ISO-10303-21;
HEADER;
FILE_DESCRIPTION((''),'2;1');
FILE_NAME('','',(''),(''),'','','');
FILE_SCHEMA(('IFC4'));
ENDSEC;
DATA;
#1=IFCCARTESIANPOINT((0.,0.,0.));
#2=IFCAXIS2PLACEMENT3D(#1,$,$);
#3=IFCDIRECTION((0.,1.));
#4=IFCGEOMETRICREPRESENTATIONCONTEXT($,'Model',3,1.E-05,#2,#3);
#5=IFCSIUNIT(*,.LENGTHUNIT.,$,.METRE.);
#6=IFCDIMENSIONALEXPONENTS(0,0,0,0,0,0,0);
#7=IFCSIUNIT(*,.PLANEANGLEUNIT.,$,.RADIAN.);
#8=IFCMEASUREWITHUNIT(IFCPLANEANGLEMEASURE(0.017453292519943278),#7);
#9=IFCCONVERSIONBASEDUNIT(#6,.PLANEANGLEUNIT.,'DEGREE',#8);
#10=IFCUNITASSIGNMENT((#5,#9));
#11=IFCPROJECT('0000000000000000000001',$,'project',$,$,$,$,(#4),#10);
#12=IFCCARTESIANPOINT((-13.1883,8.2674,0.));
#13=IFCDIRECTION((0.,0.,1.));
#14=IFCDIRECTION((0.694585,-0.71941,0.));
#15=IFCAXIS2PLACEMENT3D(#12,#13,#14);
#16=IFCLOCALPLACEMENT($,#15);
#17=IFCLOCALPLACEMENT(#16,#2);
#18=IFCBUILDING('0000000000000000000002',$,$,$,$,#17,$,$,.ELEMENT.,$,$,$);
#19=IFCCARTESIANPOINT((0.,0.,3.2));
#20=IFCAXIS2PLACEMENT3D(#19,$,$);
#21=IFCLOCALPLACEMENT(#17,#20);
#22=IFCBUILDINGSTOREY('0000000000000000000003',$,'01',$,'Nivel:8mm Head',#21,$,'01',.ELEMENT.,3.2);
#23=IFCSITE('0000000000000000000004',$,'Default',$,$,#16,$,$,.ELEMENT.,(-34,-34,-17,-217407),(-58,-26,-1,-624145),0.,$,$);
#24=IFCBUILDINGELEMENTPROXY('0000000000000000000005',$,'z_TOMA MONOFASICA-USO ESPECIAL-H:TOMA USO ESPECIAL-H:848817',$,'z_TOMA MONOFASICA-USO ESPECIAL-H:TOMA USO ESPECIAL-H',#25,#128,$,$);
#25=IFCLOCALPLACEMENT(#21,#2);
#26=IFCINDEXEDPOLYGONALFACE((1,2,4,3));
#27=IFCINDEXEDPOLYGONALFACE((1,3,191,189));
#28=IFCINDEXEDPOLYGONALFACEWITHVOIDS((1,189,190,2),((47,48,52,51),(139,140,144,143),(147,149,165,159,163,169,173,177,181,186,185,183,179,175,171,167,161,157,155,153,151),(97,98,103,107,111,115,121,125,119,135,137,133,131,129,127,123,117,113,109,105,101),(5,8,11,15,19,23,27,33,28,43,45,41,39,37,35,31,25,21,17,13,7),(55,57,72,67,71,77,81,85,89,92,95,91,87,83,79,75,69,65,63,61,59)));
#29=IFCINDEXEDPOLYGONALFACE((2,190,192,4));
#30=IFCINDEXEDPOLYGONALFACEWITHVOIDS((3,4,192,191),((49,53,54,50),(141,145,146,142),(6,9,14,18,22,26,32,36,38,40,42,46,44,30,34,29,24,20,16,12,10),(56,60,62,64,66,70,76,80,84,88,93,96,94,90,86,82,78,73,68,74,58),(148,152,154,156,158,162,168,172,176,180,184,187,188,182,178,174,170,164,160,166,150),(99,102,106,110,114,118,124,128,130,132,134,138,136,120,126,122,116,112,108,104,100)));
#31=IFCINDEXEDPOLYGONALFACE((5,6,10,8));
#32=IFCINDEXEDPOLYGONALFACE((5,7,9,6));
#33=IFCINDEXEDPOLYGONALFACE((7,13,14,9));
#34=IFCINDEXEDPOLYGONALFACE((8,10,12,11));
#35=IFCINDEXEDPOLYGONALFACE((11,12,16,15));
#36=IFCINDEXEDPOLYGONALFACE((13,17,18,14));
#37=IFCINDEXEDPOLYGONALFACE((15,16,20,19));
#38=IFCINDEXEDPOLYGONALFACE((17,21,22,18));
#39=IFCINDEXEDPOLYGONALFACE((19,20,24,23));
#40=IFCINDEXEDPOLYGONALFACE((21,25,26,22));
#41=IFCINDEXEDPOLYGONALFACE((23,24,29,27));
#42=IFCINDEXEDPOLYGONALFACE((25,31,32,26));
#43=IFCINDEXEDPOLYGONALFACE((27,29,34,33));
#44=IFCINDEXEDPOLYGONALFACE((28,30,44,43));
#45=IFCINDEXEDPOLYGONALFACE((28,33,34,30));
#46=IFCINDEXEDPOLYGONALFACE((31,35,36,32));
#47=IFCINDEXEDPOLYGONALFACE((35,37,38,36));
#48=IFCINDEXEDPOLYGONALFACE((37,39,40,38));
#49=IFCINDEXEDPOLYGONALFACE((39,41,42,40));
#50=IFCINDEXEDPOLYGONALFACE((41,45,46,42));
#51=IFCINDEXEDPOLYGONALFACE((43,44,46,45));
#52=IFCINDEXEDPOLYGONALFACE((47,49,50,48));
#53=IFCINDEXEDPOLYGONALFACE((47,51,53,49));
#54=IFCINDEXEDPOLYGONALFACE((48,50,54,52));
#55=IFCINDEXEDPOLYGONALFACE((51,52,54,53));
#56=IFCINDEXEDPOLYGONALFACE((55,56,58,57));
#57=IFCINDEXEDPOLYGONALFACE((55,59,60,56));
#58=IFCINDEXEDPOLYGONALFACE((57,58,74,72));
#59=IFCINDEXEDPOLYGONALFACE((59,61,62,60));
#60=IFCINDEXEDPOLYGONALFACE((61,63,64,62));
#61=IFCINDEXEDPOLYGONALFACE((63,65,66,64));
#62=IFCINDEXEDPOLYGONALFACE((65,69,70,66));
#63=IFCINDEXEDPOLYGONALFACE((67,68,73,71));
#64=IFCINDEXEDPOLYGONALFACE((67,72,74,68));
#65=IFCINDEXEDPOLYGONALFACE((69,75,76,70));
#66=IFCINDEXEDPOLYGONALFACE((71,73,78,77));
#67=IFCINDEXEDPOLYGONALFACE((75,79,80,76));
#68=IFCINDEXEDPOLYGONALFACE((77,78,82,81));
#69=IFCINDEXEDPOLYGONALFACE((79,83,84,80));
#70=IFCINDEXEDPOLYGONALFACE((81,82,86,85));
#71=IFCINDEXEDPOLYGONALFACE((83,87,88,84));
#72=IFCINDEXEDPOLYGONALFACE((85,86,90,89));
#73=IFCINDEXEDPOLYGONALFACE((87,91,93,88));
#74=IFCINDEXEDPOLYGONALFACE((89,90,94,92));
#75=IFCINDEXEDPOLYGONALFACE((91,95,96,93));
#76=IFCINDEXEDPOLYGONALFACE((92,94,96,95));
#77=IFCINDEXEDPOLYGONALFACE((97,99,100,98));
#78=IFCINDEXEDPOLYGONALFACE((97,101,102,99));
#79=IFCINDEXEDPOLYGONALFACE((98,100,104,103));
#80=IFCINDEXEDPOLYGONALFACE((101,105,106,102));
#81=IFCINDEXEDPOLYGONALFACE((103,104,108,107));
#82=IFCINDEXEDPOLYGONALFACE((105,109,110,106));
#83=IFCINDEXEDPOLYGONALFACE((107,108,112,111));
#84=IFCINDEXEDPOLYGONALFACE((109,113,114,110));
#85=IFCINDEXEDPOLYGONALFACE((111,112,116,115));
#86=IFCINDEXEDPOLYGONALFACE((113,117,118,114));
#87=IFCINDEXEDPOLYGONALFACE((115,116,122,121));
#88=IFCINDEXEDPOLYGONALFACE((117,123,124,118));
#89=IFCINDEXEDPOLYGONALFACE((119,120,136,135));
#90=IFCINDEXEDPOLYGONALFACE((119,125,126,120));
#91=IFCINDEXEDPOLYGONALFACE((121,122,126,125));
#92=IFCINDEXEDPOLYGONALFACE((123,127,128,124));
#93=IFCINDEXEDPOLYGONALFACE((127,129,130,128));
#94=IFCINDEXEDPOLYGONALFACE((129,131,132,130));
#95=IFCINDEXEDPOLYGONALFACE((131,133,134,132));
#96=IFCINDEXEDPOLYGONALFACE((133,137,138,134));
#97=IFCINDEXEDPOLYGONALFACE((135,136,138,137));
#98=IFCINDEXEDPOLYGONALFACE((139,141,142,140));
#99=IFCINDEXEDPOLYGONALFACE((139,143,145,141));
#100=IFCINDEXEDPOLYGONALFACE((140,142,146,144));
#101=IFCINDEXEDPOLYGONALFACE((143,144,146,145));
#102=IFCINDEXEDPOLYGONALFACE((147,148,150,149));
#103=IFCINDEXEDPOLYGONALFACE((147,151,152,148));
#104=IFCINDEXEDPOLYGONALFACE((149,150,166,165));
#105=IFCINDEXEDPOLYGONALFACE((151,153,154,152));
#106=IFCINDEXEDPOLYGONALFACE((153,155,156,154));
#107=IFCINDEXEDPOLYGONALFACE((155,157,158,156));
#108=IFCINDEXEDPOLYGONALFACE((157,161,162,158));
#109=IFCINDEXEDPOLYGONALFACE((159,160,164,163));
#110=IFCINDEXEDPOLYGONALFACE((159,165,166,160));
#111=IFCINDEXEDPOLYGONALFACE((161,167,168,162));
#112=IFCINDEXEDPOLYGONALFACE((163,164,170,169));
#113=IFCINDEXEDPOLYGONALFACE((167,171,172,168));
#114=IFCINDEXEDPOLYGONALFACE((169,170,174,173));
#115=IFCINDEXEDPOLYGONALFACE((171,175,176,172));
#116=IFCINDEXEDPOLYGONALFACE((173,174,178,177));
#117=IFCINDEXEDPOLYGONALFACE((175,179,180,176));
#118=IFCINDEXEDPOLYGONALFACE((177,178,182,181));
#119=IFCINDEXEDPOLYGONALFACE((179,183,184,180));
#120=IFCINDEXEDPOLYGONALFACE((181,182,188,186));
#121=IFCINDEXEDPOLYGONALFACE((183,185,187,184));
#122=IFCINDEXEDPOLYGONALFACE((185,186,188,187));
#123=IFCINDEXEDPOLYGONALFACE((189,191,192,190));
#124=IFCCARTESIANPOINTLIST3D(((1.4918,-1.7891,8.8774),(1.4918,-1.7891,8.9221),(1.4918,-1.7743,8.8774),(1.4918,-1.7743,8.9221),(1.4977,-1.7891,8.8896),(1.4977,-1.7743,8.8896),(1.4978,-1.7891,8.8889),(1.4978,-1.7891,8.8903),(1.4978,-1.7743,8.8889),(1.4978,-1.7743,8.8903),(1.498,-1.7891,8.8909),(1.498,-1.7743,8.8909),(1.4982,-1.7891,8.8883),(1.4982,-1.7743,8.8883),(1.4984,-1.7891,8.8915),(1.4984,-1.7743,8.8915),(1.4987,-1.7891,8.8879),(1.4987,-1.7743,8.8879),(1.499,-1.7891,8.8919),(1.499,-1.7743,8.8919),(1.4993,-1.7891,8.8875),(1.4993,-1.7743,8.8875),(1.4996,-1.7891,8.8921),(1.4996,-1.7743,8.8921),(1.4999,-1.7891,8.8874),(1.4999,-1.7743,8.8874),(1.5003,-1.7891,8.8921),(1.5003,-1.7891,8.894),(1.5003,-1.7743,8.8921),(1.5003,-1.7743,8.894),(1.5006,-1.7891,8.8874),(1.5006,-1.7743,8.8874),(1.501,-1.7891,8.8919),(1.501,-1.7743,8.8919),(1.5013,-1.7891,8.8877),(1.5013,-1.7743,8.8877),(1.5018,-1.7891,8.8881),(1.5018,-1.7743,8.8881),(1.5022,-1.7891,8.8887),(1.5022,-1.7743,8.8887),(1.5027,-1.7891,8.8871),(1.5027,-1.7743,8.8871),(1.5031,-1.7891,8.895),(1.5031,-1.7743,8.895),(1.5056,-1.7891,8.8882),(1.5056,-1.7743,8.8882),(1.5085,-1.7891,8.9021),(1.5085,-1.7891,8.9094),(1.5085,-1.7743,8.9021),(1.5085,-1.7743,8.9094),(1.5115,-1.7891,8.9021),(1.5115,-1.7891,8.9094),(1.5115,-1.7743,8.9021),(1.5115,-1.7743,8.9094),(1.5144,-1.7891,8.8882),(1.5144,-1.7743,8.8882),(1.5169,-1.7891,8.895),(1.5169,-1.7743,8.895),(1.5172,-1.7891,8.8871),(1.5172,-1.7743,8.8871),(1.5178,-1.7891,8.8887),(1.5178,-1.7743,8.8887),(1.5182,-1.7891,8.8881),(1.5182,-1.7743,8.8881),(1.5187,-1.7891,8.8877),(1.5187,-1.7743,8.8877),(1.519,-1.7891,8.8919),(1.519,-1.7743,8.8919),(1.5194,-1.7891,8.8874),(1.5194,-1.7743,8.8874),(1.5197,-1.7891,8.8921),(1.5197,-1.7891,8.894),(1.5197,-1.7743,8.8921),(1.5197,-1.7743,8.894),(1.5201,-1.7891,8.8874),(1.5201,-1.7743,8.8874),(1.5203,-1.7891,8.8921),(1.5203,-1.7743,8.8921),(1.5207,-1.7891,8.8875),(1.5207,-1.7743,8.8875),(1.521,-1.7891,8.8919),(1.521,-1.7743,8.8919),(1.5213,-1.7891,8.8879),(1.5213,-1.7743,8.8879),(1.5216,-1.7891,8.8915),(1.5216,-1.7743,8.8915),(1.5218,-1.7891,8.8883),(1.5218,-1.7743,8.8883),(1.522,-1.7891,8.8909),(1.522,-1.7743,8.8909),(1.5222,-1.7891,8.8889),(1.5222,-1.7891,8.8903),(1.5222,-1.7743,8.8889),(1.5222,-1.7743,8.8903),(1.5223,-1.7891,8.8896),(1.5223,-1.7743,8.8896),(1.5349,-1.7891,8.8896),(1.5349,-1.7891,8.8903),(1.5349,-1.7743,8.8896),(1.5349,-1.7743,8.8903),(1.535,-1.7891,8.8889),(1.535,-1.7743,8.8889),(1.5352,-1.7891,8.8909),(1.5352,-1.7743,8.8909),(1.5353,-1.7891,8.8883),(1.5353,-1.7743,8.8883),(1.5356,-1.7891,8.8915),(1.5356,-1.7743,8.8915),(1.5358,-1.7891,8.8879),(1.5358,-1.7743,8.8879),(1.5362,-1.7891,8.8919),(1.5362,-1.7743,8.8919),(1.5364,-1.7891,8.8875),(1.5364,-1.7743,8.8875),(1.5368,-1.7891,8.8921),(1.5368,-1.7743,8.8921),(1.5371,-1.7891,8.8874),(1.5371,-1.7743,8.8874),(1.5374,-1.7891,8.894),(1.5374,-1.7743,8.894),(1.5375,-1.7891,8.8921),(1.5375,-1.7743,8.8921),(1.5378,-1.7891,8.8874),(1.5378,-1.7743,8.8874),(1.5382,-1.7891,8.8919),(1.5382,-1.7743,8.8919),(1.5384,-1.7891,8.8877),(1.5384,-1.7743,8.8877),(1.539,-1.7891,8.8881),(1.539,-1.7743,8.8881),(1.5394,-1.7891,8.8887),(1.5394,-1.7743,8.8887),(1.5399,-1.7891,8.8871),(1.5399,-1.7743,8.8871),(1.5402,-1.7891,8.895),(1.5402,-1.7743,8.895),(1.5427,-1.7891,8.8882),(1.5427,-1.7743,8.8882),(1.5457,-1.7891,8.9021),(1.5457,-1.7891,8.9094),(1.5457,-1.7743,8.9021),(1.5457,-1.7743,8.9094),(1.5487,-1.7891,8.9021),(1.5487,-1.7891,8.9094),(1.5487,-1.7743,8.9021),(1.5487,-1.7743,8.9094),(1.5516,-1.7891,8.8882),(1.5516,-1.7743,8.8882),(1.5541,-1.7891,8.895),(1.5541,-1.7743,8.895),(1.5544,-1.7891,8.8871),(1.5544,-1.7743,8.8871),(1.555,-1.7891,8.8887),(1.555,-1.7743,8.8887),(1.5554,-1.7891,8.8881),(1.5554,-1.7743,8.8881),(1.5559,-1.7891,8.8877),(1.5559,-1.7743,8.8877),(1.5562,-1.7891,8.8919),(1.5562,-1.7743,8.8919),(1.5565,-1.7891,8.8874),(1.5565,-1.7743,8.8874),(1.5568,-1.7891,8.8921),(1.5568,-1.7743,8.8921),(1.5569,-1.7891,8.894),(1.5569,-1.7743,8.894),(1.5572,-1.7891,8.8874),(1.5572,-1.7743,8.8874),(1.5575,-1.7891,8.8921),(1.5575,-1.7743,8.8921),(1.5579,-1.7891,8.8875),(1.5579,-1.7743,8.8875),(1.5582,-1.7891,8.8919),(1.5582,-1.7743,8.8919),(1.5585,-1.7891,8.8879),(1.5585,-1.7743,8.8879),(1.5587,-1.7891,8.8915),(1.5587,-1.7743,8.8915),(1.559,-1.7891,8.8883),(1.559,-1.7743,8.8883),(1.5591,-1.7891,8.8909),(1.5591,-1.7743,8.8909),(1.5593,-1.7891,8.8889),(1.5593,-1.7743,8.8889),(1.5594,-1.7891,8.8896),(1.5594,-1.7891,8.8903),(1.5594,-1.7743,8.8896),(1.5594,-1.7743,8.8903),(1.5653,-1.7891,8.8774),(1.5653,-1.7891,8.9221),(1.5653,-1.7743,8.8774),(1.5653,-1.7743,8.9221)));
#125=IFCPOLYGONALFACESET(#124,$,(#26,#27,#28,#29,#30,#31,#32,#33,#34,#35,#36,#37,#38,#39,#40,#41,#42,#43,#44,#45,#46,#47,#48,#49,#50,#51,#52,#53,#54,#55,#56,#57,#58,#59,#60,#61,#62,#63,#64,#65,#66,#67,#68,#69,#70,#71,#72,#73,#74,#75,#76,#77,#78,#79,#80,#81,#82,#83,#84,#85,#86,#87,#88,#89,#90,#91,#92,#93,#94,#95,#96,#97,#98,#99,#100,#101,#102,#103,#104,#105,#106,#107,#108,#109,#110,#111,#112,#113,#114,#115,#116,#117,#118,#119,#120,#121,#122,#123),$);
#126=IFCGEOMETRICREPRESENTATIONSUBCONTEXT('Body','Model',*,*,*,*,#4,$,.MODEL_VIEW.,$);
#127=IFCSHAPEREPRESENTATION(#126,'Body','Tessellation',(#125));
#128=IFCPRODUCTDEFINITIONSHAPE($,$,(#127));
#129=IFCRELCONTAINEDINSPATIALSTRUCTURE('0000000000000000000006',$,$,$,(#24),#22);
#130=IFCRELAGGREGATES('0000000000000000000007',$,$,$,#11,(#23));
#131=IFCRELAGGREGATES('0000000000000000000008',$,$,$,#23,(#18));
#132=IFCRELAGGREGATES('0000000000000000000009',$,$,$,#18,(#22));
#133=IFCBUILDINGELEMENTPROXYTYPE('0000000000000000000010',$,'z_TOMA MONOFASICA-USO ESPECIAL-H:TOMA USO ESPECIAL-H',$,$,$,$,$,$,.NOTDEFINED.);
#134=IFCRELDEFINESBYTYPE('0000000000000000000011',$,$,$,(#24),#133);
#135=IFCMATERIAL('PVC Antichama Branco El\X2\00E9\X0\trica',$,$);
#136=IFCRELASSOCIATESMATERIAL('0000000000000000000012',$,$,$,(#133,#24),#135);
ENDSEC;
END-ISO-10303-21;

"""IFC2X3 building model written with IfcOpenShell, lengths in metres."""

from ifc_helpers import new_model, entity, si_unit, converted_unit, direction, frame, frame_2d, origin, place, context, subcontext, project, spatial, polyline, circle_curve, parameter, trimmed, segment, composite_curve, outline, extrude, source, transform, mapped, material, type_object, type_shapes, element, save


model = new_model("IFC2X3")

# Units and contexts
model_context = context("Model", 3, precision=1e-05, world=origin(), true_north=direction((0.0, 1.0)))
body_context = subcontext(model_context, "Body", "Model", "MODEL_VIEW")
ifc_project = project(units=[si_unit("LENGTHUNIT", "METRE"), converted_unit("PLANEANGLEUNIT", "DEGREE", entity("IfcPlaneAngleMeasure", 0.017453292519943278), si_unit("PLANEANGLEUNIT", "RADIAN"), dimensions=[0, 0, 0, 0, 0, 0, 0])], contexts=[model_context])

# Site, building, storey
site_placement = place(None, frame((-13.1883, 8.2674, 0.0), z_axis=(0.0, 0.0, 1.0), x_axis=(0.694585, -0.71941, 0.0)))
site = spatial("IfcSite", under=ifc_project, at=site_placement, Name="Default", CompositionType="ELEMENT", RefLatitude=(-34, -34, -17, -217407), RefLongitude=(-58, -26, -1, -624145), RefElevation=0.0)
building_placement = place(site_placement, origin())
building = spatial("IfcBuilding", under=site, at=building_placement, CompositionType="ELEMENT")
storey_placement = place(building_placement, frame((0.0, 0.0, 3.2)))
storey = spatial("IfcBuildingStorey", under=building, at=storey_placement, Name="01", ObjectType="Nivel:8mm Head", LongName="01", CompositionType="ELEMENT", Elevation=3.2)

# Building element proxy
ifc_material_1 = material(Name="PVC Antichama Branco Elétrica")
building_element_proxy_type_1 = type_object("IfcBuildingElementProxyType", Name="z_TOMA MONOFASICA-USO ESPECIAL-H:TOMA USO ESPECIAL-H", PredefinedType="NOTDEFINED", material=ifc_material_1)
shared_shape_1 = source(origin(), body_context, "Body", "SweptSolid", [
    extrude(outline(polyline([(-0.0368, -0.0223), (0.0368, -0.0223), (0.0368, 0.0223), (-0.0368, 0.0223), (-0.0368, -0.0223)]), holes=[composite_curve([segment(polyline([(0.0141, 0.0115), (0.0116, 0.0047)]), True, "CONTINUOUS"), segment(polyline([(0.0116, 0.0047), (0.0088, 0.0057)]), True, "CONTINUOUS"), segment(polyline([(0.0088, 0.0057), (0.0096, 0.0078)]), True, "CONTINUOUS"), segment(trimmed(circle_curve(frame_2d((0.0087, 0.0099), x_axis=(1.0, 0.0)), 0.0024), [parameter(27.118901)], [parameter(292.881099)], True, "PARAMETER"), False, "CONTINUOUS"), segment(polyline([(0.0108, 0.011), (0.0113, 0.0126)]), True, "CONTINUOUS"), segment(polyline([(0.0113, 0.0126), (0.0141, 0.0115)]), True, "CONTINUOUS")], self_intersect=False), composite_curve([segment(polyline([(0.0255, 0.0047), (0.023, 0.0115)]), True, "CONTINUOUS"), segment(polyline([(0.023, 0.0115), (0.0258, 0.0126)]), True, "CONTINUOUS"), segment(polyline([(0.0258, 0.0126), (0.0264, 0.011)]), True, "CONTINUOUS"), segment(trimmed(circle_curve(frame_2d((0.0285, 0.0099), x_axis=(1.0, 0.0)), 0.0024), [parameter(247.118901)], [parameter(152.881099)], True, "PARAMETER"), False, "CONTINUOUS"), segment(polyline([(0.0276, 0.0078), (0.0283, 0.0057)]), True, "CONTINUOUS"), segment(polyline([(0.0283, 0.0057), (0.0255, 0.0047)]), True, "CONTINUOUS")], self_intersect=False), polyline([(0.0201, -0.0024), (0.0201, -0.0097), (0.0171, -0.0097), (0.0171, -0.0024), (0.0201, -0.0024)]), composite_curve([segment(polyline([(-0.0141, 0.0115), (-0.0113, 0.0126)]), True, "CONTINUOUS"), segment(polyline([(-0.0113, 0.0126), (-0.0108, 0.011)]), True, "CONTINUOUS"), segment(trimmed(circle_curve(frame_2d((-0.0087, 0.0099), x_axis=(1.0, 0.0)), 0.0024), [parameter(247.118901)], [parameter(152.881099)], True, "PARAMETER"), False, "CONTINUOUS"), segment(polyline([(-0.0096, 0.0078), (-0.0088, 0.0057)]), True, "CONTINUOUS"), segment(polyline([(-0.0088, 0.0057), (-0.0116, 0.0047)]), True, "CONTINUOUS"), segment(polyline([(-0.0116, 0.0047), (-0.0141, 0.0115)]), True, "CONTINUOUS")], self_intersect=False), composite_curve([segment(polyline([(-0.0255, 0.0047), (-0.0283, 0.0057)]), True, "CONTINUOUS"), segment(polyline([(-0.0283, 0.0057), (-0.0276, 0.0078)]), True, "CONTINUOUS"), segment(trimmed(circle_curve(frame_2d((-0.0285, 0.0099), x_axis=(1.0, 0.0)), 0.0024), [parameter(27.118901)], [parameter(292.881099)], True, "PARAMETER"), False, "CONTINUOUS"), segment(polyline([(-0.0264, 0.011), (-0.0258, 0.0126)]), True, "CONTINUOUS"), segment(polyline([(-0.0258, 0.0126), (-0.023, 0.0115)]), True, "CONTINUOUS"), segment(polyline([(-0.023, 0.0115), (-0.0255, 0.0047)]), True, "CONTINUOUS")], self_intersect=False), polyline([(-0.0201, -0.0024), (-0.0171, -0.0024), (-0.0171, -0.0097), (-0.0201, -0.0097), (-0.0201, -0.0024)])]), frame((0.0, -0.005, 0.0223), z_axis=(0.0, 1.0, 0.0), x_axis=(1.0, 0.0, 0.0)), (0.0, 0.0, 1.0), 0.0148),
])
type_shapes(building_element_proxy_type_1, [shared_shape_1])
for number, where, z_axis, x_axis, name in (
    (1, (1.5286, -1.7793, 8.8774), (0.0, 0.0, 1.0), (-1.0, 0.0, 0.0), "z_TOMA MONOFASICA-USO ESPECIAL-H:TOMA USO ESPECIAL-H:848817"),
):
    element("IfcBuildingElementProxy", number, at=place(storey_placement, frame(where, z_axis=z_axis, x_axis=x_axis)), inside=storey, type_object=building_element_proxy_type_1, material=ifc_material_1, Name=name, ObjectType="z_TOMA MONOFASICA-USO ESPECIAL-H:TOMA USO ESPECIAL-H", context=body_context, shape_type="MappedRepresentation", body=[
        mapped(shared_shape_1, transform((0.0, 0.0, 0.0), scale=1.0)),
    ])

save(model, "model.ifc")
